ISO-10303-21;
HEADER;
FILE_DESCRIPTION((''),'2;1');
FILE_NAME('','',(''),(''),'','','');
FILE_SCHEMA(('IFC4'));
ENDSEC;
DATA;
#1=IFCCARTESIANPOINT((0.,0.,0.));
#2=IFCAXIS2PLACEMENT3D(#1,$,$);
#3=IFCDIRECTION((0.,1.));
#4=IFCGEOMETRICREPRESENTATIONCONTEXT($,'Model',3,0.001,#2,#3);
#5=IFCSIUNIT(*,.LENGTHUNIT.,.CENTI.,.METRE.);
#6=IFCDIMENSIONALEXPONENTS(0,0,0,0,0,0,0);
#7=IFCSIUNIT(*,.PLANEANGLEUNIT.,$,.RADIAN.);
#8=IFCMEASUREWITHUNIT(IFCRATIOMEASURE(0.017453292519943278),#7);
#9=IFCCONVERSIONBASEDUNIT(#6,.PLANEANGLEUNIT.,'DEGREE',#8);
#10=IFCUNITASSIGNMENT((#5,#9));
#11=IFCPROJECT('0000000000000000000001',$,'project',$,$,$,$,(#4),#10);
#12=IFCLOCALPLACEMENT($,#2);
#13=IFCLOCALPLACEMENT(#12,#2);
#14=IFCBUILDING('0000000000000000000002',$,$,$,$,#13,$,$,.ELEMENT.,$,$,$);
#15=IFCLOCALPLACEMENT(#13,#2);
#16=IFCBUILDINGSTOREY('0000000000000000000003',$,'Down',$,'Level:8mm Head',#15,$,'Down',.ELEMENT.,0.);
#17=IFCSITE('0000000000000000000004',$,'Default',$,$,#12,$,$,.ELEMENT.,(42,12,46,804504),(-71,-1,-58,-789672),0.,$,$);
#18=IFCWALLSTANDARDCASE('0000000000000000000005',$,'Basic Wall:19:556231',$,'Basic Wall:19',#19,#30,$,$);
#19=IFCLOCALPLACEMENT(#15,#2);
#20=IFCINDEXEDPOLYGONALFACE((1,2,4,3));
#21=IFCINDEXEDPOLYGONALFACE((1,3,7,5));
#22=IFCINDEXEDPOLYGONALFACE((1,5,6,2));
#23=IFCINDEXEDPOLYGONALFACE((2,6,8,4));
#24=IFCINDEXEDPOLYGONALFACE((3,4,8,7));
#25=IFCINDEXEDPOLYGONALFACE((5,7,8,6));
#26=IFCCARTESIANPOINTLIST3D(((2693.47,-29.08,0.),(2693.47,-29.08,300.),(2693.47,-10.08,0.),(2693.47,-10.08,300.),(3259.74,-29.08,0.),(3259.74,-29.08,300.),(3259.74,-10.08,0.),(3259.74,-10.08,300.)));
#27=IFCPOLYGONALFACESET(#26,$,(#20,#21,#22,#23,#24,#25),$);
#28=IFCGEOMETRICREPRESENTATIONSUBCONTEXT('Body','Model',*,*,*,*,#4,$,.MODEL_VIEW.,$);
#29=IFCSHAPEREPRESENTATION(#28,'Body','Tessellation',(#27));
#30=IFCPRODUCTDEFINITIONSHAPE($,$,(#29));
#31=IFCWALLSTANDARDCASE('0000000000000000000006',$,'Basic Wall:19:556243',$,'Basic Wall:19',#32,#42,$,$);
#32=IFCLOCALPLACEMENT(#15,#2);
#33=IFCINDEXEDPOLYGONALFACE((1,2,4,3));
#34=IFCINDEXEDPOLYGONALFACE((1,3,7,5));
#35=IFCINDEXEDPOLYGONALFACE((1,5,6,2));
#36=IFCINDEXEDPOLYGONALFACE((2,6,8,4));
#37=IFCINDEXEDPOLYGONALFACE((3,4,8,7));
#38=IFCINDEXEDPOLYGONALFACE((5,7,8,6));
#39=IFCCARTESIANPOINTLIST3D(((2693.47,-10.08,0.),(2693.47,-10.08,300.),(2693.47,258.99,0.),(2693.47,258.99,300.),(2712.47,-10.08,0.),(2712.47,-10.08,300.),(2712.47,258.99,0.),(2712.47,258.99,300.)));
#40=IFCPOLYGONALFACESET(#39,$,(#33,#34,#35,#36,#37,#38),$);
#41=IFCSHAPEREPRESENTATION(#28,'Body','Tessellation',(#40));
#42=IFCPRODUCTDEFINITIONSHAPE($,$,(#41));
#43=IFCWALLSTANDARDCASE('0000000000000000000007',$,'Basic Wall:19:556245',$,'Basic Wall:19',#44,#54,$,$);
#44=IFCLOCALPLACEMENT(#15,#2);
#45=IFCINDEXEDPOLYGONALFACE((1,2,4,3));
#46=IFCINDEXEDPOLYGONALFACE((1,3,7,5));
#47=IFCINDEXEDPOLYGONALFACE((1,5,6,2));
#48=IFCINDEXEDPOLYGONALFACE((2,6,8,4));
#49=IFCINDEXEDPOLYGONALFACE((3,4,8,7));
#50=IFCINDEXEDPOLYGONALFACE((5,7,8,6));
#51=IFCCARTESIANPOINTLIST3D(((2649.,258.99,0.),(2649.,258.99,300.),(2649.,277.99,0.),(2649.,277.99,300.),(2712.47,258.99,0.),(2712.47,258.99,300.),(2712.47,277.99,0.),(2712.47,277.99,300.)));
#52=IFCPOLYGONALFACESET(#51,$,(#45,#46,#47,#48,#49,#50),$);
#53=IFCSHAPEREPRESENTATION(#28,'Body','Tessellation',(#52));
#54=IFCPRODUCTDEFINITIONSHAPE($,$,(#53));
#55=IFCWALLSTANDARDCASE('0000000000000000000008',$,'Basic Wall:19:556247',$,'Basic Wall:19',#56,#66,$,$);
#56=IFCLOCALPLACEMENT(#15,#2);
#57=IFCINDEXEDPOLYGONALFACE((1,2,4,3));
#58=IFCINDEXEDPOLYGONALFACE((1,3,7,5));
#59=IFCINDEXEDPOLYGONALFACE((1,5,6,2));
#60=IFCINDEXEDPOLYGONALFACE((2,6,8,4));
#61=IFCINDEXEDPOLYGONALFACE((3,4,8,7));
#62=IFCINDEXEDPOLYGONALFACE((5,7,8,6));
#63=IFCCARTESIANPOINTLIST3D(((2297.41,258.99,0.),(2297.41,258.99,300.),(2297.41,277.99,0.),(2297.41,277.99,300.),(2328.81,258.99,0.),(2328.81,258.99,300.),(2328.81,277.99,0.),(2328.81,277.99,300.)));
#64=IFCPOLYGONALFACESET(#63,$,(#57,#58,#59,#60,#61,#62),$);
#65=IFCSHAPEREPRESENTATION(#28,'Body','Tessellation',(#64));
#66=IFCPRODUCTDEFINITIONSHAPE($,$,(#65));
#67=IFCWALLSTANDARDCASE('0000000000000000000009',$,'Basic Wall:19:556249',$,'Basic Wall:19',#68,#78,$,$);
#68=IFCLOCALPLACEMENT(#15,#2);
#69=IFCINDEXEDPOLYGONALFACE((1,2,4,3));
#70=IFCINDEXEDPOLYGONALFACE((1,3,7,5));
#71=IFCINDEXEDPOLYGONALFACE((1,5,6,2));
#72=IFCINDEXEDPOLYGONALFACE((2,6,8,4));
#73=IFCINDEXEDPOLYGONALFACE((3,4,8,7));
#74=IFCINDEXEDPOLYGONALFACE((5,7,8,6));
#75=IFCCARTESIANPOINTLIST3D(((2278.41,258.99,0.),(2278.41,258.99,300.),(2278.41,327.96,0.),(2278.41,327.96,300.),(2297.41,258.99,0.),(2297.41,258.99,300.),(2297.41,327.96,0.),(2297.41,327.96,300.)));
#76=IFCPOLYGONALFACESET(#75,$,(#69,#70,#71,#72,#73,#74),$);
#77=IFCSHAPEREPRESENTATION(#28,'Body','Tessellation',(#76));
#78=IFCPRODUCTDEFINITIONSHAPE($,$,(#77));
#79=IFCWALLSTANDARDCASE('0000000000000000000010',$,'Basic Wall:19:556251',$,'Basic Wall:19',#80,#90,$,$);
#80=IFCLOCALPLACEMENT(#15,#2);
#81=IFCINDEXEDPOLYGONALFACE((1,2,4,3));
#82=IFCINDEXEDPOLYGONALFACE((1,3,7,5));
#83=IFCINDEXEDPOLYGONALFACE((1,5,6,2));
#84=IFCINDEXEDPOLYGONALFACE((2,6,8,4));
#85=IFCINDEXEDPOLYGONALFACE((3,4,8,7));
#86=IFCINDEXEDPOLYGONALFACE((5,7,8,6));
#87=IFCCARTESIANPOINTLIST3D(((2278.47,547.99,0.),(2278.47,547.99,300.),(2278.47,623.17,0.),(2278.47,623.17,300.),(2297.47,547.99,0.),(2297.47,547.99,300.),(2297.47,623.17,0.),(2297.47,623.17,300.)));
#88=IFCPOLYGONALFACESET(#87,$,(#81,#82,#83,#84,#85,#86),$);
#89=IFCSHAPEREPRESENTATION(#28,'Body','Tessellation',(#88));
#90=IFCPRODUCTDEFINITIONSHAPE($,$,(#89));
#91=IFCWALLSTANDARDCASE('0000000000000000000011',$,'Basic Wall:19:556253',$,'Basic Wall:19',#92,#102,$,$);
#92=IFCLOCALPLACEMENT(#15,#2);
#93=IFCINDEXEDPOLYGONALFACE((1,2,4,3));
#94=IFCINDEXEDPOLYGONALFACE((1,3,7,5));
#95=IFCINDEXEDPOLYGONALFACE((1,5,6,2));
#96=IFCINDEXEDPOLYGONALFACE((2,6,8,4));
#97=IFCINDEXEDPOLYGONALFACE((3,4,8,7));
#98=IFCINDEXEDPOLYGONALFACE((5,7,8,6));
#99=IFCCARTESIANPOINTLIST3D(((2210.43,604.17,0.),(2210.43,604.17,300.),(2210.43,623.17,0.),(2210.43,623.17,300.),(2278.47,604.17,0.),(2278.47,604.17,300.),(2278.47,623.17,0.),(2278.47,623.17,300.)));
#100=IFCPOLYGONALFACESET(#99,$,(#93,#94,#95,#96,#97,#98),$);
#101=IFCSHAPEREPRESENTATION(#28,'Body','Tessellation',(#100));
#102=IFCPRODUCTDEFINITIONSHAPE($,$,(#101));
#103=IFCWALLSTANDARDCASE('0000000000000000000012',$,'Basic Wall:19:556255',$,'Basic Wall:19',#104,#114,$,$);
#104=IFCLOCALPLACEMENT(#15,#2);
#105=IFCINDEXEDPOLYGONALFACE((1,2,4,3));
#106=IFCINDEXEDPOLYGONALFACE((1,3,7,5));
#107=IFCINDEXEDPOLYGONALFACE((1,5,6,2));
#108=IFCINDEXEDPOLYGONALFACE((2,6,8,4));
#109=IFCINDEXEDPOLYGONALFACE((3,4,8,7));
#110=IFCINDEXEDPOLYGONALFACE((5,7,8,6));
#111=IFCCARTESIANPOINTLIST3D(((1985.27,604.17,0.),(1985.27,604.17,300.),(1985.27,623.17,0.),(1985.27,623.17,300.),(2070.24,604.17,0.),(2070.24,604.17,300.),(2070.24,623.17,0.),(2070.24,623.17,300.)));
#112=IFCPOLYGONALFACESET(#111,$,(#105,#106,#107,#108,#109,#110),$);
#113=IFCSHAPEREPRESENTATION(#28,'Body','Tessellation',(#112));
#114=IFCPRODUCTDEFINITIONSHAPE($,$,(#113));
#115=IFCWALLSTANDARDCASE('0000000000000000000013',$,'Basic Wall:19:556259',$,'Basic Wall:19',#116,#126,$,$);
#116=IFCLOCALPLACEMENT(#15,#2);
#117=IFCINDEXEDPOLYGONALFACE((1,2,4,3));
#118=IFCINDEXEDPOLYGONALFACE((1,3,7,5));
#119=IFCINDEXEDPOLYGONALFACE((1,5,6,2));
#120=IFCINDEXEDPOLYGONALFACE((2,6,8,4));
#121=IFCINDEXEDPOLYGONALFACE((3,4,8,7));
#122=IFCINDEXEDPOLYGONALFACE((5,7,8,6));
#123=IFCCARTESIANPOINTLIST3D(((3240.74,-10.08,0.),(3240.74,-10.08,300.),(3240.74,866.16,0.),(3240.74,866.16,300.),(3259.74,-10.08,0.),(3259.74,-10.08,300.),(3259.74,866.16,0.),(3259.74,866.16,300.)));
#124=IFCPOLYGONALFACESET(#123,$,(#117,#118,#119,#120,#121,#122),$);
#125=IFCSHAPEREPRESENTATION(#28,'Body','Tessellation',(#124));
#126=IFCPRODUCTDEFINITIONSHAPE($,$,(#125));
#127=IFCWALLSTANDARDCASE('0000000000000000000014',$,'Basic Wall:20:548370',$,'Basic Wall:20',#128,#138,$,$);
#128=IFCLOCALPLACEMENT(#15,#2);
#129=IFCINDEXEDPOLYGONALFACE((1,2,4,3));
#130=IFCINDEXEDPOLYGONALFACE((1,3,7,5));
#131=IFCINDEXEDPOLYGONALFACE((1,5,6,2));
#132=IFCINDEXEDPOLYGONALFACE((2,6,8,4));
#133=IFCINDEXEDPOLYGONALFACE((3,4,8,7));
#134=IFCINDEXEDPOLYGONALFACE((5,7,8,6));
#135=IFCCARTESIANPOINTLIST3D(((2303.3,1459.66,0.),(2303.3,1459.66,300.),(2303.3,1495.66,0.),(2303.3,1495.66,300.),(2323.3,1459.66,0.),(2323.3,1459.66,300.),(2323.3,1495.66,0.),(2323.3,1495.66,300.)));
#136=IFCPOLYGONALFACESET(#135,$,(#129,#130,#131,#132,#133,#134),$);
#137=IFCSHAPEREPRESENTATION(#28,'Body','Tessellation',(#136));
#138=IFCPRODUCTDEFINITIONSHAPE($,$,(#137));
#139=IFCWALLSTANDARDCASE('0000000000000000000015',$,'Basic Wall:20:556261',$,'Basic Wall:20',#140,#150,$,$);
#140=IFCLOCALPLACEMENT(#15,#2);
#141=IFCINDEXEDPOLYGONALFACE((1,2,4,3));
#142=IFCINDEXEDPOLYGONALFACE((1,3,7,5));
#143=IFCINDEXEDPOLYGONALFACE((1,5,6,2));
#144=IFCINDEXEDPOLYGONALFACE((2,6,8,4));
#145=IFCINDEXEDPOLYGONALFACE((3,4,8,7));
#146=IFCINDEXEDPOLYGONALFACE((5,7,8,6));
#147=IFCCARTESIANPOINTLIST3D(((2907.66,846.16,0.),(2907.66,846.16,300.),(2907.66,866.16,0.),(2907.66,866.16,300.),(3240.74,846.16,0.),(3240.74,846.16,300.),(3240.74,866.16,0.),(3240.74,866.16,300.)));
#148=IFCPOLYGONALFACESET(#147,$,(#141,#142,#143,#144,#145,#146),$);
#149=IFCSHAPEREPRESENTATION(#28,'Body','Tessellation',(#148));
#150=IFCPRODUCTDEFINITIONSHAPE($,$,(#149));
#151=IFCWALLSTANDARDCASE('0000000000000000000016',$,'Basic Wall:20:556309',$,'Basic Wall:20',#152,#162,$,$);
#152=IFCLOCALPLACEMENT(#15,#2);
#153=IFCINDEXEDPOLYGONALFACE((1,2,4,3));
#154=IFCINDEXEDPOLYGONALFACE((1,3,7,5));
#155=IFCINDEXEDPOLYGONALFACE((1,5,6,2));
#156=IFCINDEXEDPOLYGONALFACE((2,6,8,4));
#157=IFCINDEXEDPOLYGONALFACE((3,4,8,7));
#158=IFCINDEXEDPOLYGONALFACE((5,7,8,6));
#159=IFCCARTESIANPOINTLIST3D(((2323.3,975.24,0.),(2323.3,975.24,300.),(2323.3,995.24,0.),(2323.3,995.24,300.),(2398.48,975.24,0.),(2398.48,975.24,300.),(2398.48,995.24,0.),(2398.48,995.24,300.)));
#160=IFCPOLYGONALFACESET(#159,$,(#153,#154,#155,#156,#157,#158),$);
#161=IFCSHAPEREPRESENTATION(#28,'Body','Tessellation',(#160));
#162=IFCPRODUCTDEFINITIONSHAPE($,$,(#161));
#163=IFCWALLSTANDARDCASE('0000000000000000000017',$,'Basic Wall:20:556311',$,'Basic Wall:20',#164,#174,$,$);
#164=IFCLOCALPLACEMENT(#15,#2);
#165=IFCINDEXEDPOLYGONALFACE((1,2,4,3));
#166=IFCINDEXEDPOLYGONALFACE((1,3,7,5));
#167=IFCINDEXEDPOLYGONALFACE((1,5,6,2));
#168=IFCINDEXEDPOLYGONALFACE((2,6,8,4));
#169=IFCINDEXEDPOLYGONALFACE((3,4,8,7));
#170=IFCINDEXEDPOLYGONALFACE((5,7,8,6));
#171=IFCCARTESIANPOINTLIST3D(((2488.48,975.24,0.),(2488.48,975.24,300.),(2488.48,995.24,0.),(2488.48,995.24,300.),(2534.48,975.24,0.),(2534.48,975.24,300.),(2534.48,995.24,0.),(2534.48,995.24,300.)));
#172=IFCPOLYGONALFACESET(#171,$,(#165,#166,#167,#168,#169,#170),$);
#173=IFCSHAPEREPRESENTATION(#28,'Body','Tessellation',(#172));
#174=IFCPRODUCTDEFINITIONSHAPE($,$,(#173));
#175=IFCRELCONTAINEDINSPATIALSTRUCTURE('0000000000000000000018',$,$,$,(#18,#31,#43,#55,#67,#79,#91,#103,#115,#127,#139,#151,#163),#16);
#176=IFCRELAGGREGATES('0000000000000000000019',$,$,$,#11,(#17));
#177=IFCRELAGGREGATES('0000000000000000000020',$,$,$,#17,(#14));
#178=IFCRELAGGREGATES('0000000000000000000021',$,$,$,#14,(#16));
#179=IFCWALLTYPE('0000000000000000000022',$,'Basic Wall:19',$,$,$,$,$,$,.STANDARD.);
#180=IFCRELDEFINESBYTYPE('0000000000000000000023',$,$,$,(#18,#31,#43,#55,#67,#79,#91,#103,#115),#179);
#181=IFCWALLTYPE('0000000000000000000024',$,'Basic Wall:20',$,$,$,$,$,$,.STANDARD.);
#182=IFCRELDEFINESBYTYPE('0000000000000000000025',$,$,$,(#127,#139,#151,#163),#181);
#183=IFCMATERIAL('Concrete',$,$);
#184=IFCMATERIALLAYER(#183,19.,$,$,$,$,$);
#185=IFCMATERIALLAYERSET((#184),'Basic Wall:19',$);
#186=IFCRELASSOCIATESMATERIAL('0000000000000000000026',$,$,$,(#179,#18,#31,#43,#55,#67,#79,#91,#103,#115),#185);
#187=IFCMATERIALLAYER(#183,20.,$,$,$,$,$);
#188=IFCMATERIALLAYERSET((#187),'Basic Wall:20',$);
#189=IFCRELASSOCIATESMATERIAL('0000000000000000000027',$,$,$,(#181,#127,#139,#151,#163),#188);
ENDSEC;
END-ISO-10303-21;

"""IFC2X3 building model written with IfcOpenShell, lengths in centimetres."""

from ifc_helpers import new_model, entity, si_unit, converted_unit, direction, frame, frame_2d, origin, place, context, subcontext, project, spatial, rectangle, extrude, material, layer, layer_set, layer_usage, type_object, element, save


model = new_model("IFC2X3")

# Units and contexts
model_context = context("Model", 3, precision=0.001, world=origin(), true_north=direction((0.0, 1.0)))
body_context = subcontext(model_context, "Body", "Model", "MODEL_VIEW")
ifc_project = project(units=[si_unit("LENGTHUNIT", "METRE", prefix="CENTI"), converted_unit("PLANEANGLEUNIT", "DEGREE", entity("IfcRatioMeasure", 0.017453292519943278), si_unit("PLANEANGLEUNIT", "RADIAN"), dimensions=[0, 0, 0, 0, 0, 0, 0])], contexts=[model_context])

# Site, building, storey
site_placement = place(None, origin())
site = spatial("IfcSite", under=ifc_project, at=site_placement, Name="Default", CompositionType="ELEMENT", RefLatitude=(42, 12, 46, 804504), RefLongitude=(-71, -1, -58, -789672), RefElevation=0.0)
building_placement = place(site_placement, origin())
building = spatial("IfcBuilding", under=site, at=building_placement, CompositionType="ELEMENT")
storey_placement = place(building_placement, origin())
storey = spatial("IfcBuildingStorey", under=building, at=storey_placement, Name="Down", ObjectType="Level:8mm Head", LongName="Down", CompositionType="ELEMENT", Elevation=0.0)

# Walls
ifc_material = material(Name="Concrete")
ifc_layer_1 = layer(ifc_material, 19.0)
ifc_layer_set_1 = layer_set([ifc_layer_1], Name="Basic Wall:19")
ifc_layer_usage_1 = layer_usage(ifc_layer_set_1, "AXIS2", "NEGATIVE", 9.5)
wall_type_1 = type_object("IfcWallType", Name="Basic Wall:19", PredefinedType="STANDARD", material=ifc_layer_set_1)
wall_1_placement = place(storey_placement, frame((3259.74, -19.58, 0.0), z_axis=(0.0, 0.0, 1.0), x_axis=(-1.0, 0.0, 0.0)))
element("IfcWallStandardCase", 1, at=wall_1_placement, inside=storey, type_object=wall_type_1, material=ifc_layer_usage_1, Name="Basic Wall:19:556231", ObjectType="Basic Wall:19", context=body_context, shape_type="SweptSolid", body=[
    extrude(rectangle(XDim=566.27, YDim=19.0, at=frame_2d((283.13, 0.0), x_axis=(-1.0, 0.0))), origin(), (0.0, 0.0, 1.0), 300.0),
])
ifc_layer_usage_2 = layer_usage(ifc_layer_set_1, "AXIS2", "NEGATIVE", 9.5)
wall_2_placement = place(storey_placement, frame((2702.97, -10.08, 0.0), z_axis=(0.0, 0.0, 1.0), x_axis=(0.0, 1.0, 0.0)))
element("IfcWallStandardCase", 2, at=wall_2_placement, inside=storey, type_object=wall_type_1, material=ifc_layer_usage_2, Name="Basic Wall:19:556243", ObjectType="Basic Wall:19", context=body_context, shape_type="SweptSolid", body=[
    extrude(rectangle(XDim=269.06, YDim=19.0, at=frame_2d((134.53, 0.0), x_axis=(-1.0, 0.0))), origin(), (0.0, 0.0, 1.0), 300.0),
])
ifc_layer_usage_3 = layer_usage(ifc_layer_set_1, "AXIS2", "POSITIVE", -9.5)
wall_3_placement = place(storey_placement, frame((2712.47, 268.49, 0.0), z_axis=(0.0, 0.0, 1.0), x_axis=(-1.0, 0.0, 0.0)))
element("IfcWallStandardCase", 3, at=wall_3_placement, inside=storey, type_object=wall_type_1, material=ifc_layer_usage_3, Name="Basic Wall:19:556245", ObjectType="Basic Wall:19", context=body_context, shape_type="SweptSolid", body=[
    extrude(rectangle(XDim=63.47, YDim=19.0, at=frame_2d((31.74, 0.0), x_axis=(-1.0, 0.0))), origin(), (0.0, 0.0, 1.0), 300.0),
])
ifc_layer_usage_4 = layer_usage(ifc_layer_set_1, "AXIS2", "POSITIVE", -9.5)
wall_4_placement = place(storey_placement, frame((2328.81, 268.49, 0.0), z_axis=(0.0, 0.0, 1.0), x_axis=(-1.0, 0.0, 0.0)))
element("IfcWallStandardCase", 4, at=wall_4_placement, inside=storey, type_object=wall_type_1, material=ifc_layer_usage_4, Name="Basic Wall:19:556247", ObjectType="Basic Wall:19", context=body_context, shape_type="SweptSolid", body=[
    extrude(rectangle(XDim=31.4, YDim=19.0, at=frame_2d((15.7, 0.0), x_axis=(-1.0, 0.0))), origin(), (0.0, 0.0, 1.0), 300.0),
])
ifc_layer_usage_5 = layer_usage(ifc_layer_set_1, "AXIS2", "NEGATIVE", 9.5)
wall_5_placement = place(storey_placement, frame((2287.91, 258.99, 0.0), z_axis=(0.0, 0.0, 1.0), x_axis=(0.0, 1.0, 0.0)))
element("IfcWallStandardCase", 5, at=wall_5_placement, inside=storey, type_object=wall_type_1, material=ifc_layer_usage_5, Name="Basic Wall:19:556249", ObjectType="Basic Wall:19", context=body_context, shape_type="SweptSolid", body=[
    extrude(rectangle(XDim=68.98, YDim=19.0, at=frame_2d((34.49, 0.0), x_axis=(-1.0, 0.0))), origin(), (0.0, 0.0, 1.0), 300.0),
])
ifc_layer_usage_6 = layer_usage(ifc_layer_set_1, "AXIS2", "POSITIVE", -9.5)
wall_6_placement = place(storey_placement, frame((2287.97, 547.99, 0.0), z_axis=(0.0, 0.0, 1.0), x_axis=(0.0, 1.0, 0.0)))
element("IfcWallStandardCase", 6, at=wall_6_placement, inside=storey, type_object=wall_type_1, material=ifc_layer_usage_6, Name="Basic Wall:19:556251", ObjectType="Basic Wall:19", context=body_context, shape_type="SweptSolid", body=[
    extrude(rectangle(XDim=75.18, YDim=19.0, at=frame_2d((37.59, 0.0), x_axis=(-1.0, 0.0))), origin(), (0.0, 0.0, 1.0), 300.0),
])
ifc_layer_usage_7 = layer_usage(ifc_layer_set_1, "AXIS2", "POSITIVE", -9.5)
wall_7_placement = place(storey_placement, frame((2278.47, 613.67, 0.0), z_axis=(0.0, 0.0, 1.0), x_axis=(-1.0, 0.0, 0.0)))
element("IfcWallStandardCase", 7, at=wall_7_placement, inside=storey, type_object=wall_type_1, material=ifc_layer_usage_7, Name="Basic Wall:19:556253", ObjectType="Basic Wall:19", context=body_context, shape_type="SweptSolid", body=[
    extrude(rectangle(XDim=68.04, YDim=19.0, at=frame_2d((34.02, 0.0), x_axis=(-1.0, 0.0))), origin(), (0.0, 0.0, 1.0), 300.0),
])
ifc_layer_usage_8 = layer_usage(ifc_layer_set_1, "AXIS2", "POSITIVE", -9.5)
wall_8_placement = place(storey_placement, frame((2070.24, 613.67, 0.0), z_axis=(0.0, 0.0, 1.0), x_axis=(-1.0, 0.0, 0.0)))
element("IfcWallStandardCase", 8, at=wall_8_placement, inside=storey, type_object=wall_type_1, material=ifc_layer_usage_8, Name="Basic Wall:19:556255", ObjectType="Basic Wall:19", context=body_context, shape_type="SweptSolid", body=[
    extrude(rectangle(XDim=84.98, YDim=19.0, at=frame_2d((42.49, 0.0), x_axis=(-1.0, 0.0))), origin(), (0.0, 0.0, 1.0), 300.0),
])
ifc_layer_usage_9 = layer_usage(ifc_layer_set_1, "AXIS2", "POSITIVE", -9.5)
wall_9_placement = place(storey_placement, frame((3250.24, -10.08, 0.0), z_axis=(0.0, 0.0, 1.0), x_axis=(0.0, 1.0, 0.0)))
element("IfcWallStandardCase", 9, at=wall_9_placement, inside=storey, type_object=wall_type_1, material=ifc_layer_usage_9, Name="Basic Wall:19:556259", ObjectType="Basic Wall:19", context=body_context, shape_type="SweptSolid", body=[
    extrude(rectangle(XDim=876.23, YDim=19.0, at=frame_2d((438.12, 0.0), x_axis=(-1.0, 0.0))), origin(), (0.0, 0.0, 1.0), 300.0),
])
ifc_layer_2 = layer(ifc_material, 20.0)
ifc_layer_set_2 = layer_set([ifc_layer_2], Name="Basic Wall:20")
ifc_layer_usage_10 = layer_usage(ifc_layer_set_2, "AXIS2", "NEGATIVE", 10.0)
wall_type_2 = type_object("IfcWallType", Name="Basic Wall:20", PredefinedType="STANDARD", material=ifc_layer_set_2)
wall_10_placement = place(storey_placement, frame((2313.3, 1495.66, 0.0), z_axis=(0.0, 0.0, 1.0), x_axis=(0.0, -1.0, 0.0)))
element("IfcWallStandardCase", 10, at=wall_10_placement, inside=storey, type_object=wall_type_2, material=ifc_layer_usage_10, Name="Basic Wall:20:548370", ObjectType="Basic Wall:20", context=body_context, shape_type="SweptSolid", body=[
    extrude(rectangle(XDim=36.0, YDim=20.0, at=frame_2d((18.0, 0.0), x_axis=(-1.0, 0.0))), origin(), (0.0, 0.0, 1.0), 300.0),
])
ifc_layer_usage_11 = layer_usage(ifc_layer_set_2, "AXIS2", "POSITIVE", -10.0)
wall_11_placement = place(storey_placement, frame((2907.66, 856.16, 0.0)))
element("IfcWallStandardCase", 11, at=wall_11_placement, inside=storey, type_object=wall_type_2, material=ifc_layer_usage_11, Name="Basic Wall:20:556261", ObjectType="Basic Wall:20", context=body_context, shape_type="SweptSolid", body=[
    extrude(rectangle(XDim=333.07, YDim=20.0, at=frame_2d((166.54, 0.0), x_axis=(-1.0, 0.0))), origin(), (0.0, 0.0, 1.0), 300.0),
])
ifc_layer_usage_12 = layer_usage(ifc_layer_set_2, "AXIS2", "NEGATIVE", 10.0)
wall_12_placement = place(storey_placement, frame((2323.3, 985.24, 0.0)))
element("IfcWallStandardCase", 12, at=wall_12_placement, inside=storey, type_object=wall_type_2, material=ifc_layer_usage_12, Name="Basic Wall:20:556309", ObjectType="Basic Wall:20", context=body_context, shape_type="SweptSolid", body=[
    extrude(rectangle(XDim=75.18, YDim=20.0, at=frame_2d((37.59, 0.0), x_axis=(-1.0, 0.0))), origin(), (0.0, 0.0, 1.0), 300.0),
])
ifc_layer_usage_13 = layer_usage(ifc_layer_set_2, "AXIS2", "NEGATIVE", 10.0)
wall_13_placement = place(storey_placement, frame((2488.48, 985.24, 0.0)))
element("IfcWallStandardCase", 13, at=wall_13_placement, inside=storey, type_object=wall_type_2, material=ifc_layer_usage_13, Name="Basic Wall:20:556311", ObjectType="Basic Wall:20", context=body_context, shape_type="SweptSolid", body=[
    extrude(rectangle(XDim=46.0, YDim=20.0, at=frame_2d((23.0, 0.0), x_axis=(-1.0, 0.0))), origin(), (0.0, 0.0, 1.0), 300.0),
])

save(model, "model.ifc")
